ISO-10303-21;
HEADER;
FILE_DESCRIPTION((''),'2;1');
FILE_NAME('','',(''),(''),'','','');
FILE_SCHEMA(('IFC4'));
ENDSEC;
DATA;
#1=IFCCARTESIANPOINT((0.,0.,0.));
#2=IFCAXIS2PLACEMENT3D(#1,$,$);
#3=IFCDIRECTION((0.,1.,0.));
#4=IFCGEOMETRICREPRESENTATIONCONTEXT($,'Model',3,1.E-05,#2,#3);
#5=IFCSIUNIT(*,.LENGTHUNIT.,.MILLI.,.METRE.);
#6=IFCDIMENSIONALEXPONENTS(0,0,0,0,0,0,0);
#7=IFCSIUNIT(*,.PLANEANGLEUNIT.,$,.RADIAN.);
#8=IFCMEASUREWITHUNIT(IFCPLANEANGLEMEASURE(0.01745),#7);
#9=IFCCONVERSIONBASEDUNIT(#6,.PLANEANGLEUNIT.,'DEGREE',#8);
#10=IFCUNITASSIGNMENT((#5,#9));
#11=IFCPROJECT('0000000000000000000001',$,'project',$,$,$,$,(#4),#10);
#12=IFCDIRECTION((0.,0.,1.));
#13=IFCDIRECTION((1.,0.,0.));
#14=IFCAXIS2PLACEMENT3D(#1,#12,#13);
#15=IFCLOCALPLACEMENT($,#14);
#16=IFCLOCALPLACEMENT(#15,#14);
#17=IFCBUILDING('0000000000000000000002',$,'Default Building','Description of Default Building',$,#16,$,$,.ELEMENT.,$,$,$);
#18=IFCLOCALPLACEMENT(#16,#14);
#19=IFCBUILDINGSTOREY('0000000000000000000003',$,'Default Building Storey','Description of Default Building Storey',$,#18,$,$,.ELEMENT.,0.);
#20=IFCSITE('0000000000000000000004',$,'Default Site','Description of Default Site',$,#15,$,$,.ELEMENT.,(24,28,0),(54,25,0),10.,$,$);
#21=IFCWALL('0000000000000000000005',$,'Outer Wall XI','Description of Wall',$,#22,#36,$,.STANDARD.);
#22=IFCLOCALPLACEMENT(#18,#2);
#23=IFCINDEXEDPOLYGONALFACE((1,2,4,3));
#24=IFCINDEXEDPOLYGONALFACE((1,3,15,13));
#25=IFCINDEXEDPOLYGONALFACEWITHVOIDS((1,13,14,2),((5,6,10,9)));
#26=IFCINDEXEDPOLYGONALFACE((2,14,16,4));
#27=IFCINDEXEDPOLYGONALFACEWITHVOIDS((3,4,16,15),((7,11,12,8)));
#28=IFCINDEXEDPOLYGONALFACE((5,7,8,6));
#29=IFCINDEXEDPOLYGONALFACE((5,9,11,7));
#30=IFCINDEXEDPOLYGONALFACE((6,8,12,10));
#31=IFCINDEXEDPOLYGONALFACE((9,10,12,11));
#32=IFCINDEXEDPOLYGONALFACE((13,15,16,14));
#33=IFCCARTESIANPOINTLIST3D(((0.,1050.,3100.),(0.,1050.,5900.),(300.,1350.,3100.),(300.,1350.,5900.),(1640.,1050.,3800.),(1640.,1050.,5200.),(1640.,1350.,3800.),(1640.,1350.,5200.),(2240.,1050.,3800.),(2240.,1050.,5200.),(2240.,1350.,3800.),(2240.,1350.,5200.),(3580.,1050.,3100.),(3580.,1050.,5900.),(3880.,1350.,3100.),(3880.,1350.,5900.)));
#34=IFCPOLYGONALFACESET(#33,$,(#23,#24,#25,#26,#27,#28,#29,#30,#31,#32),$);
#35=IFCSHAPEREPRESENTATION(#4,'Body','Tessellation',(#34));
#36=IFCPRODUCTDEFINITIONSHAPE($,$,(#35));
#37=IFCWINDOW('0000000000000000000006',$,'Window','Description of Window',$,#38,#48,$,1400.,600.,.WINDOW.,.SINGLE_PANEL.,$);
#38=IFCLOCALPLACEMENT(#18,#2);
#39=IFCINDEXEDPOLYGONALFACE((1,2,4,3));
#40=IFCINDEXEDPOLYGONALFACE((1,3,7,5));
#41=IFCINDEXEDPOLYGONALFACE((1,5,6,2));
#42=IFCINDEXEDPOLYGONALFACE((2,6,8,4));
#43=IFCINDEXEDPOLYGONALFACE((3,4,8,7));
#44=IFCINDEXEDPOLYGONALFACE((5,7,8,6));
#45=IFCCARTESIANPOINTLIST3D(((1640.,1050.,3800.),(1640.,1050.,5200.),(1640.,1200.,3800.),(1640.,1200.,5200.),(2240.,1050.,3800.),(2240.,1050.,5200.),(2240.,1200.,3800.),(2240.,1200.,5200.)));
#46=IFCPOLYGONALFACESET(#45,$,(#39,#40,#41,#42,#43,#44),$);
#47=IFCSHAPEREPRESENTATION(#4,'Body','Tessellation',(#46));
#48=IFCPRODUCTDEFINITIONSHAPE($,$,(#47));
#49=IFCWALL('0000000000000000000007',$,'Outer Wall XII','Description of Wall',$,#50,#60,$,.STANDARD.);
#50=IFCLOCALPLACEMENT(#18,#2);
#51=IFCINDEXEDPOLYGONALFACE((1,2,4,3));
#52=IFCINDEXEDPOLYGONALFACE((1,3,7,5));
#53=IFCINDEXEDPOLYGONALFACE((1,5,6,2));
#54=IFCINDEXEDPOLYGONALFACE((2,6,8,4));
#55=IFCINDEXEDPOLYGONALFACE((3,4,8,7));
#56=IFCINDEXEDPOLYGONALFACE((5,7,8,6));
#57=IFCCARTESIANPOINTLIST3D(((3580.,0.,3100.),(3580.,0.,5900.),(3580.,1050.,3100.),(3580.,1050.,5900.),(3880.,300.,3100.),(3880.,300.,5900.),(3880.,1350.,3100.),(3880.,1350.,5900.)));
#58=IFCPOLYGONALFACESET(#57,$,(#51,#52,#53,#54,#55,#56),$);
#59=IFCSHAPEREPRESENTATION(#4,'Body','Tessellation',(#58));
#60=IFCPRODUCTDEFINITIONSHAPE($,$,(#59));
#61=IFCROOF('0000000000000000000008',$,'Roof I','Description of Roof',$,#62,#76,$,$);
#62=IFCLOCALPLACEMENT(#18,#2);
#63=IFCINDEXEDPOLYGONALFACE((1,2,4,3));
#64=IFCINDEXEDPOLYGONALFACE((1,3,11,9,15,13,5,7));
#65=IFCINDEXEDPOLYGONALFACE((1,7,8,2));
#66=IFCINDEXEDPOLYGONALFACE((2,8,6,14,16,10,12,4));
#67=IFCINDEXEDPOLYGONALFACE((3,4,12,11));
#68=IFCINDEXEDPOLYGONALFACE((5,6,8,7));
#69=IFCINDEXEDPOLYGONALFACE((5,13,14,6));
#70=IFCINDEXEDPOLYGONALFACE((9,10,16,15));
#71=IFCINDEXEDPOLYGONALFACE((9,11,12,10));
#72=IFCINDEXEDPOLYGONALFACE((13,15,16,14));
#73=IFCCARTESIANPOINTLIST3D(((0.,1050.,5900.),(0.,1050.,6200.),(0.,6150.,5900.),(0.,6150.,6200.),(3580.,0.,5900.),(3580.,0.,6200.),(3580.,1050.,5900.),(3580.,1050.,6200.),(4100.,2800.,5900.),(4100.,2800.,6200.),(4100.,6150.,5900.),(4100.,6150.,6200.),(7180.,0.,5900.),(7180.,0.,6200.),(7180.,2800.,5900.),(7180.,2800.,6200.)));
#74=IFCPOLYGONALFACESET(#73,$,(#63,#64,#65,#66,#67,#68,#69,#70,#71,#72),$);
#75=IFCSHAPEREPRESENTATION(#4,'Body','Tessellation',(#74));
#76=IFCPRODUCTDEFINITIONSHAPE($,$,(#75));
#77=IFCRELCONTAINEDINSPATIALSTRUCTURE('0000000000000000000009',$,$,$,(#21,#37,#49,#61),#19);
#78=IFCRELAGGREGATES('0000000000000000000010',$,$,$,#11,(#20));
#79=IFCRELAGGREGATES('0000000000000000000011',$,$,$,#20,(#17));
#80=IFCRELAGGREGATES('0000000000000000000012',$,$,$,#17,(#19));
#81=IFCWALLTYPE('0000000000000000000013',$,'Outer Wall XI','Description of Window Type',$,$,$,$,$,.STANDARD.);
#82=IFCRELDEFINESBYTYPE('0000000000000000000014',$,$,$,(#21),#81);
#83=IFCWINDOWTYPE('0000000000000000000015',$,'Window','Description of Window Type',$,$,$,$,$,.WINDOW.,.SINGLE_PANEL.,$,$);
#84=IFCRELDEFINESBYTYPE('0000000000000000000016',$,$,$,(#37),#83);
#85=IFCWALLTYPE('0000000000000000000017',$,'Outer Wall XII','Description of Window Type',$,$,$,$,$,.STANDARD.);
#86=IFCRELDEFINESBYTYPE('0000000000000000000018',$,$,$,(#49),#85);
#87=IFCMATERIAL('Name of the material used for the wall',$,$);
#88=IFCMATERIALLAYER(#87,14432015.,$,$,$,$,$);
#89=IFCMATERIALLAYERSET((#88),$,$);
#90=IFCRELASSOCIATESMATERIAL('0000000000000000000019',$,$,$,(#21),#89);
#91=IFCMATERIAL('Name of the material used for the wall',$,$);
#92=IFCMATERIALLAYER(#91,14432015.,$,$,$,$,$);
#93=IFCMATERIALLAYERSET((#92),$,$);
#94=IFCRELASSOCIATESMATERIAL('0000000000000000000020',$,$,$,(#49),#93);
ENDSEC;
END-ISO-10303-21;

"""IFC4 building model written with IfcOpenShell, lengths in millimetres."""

from ifc_helpers import new_model, entity, si_unit, converted_unit, direction, frame, origin, origin_with_axes, place, context, project, spatial, polyline, outline, extrude, material, layer, layer_set, layer_usage, type_object, element, fill, save


model = new_model("IFC4")

# Units and contexts
model_context = context("Model", 3, precision=1e-05, world=origin(), true_north=direction((0.0, 1.0, 0.0)))
ifc_project = project(units=[si_unit("LENGTHUNIT", "METRE", prefix="MILLI"), converted_unit("PLANEANGLEUNIT", "DEGREE", entity("IfcPlaneAngleMeasure", 0.01745), si_unit("PLANEANGLEUNIT", "RADIAN"), dimensions=[0, 0, 0, 0, 0, 0, 0])], contexts=[model_context])

# Site, building, storey
site_placement = place(None, origin_with_axes())
site = spatial("IfcSite", under=ifc_project, at=site_placement, Name="Default Site", Description="Description of Default Site", CompositionType="ELEMENT", RefLatitude=(24, 28, 0), RefLongitude=(54, 25, 0), RefElevation=10.0)
building_placement = place(site_placement, origin_with_axes())
building = spatial("IfcBuilding", under=site, at=building_placement, Name="Default Building", Description="Description of Default Building", CompositionType="ELEMENT")
storey_placement = place(building_placement, origin_with_axes())
storey = spatial("IfcBuildingStorey", under=building, at=storey_placement, Name="Default Building Storey", Description="Description of Default Building Storey", CompositionType="ELEMENT", Elevation=0.0)

# Wall, opening, window
ifc_material_1 = material(Name="Name of the material used for the wall")
ifc_layer_1 = layer(ifc_material_1, 14432015.0)
ifc_layer_set_1 = layer_set([ifc_layer_1])
ifc_layer_usage_1 = layer_usage(ifc_layer_set_1, "AXIS2", "POSITIVE", -7216007.5)
wall_type_1 = type_object("IfcWallType", Name="Outer Wall XI", Description="Description of Window Type", PredefinedType="STANDARD")
wall_1_placement = place(storey_placement, frame((150.0, 1200.0, 3100.0), z_axis=(0.0, 0.0, 1.0), x_axis=(1.0, 0.0, 0.0)))
wall_1 = element("IfcWall", 1, at=wall_1_placement, inside=storey, type_object=wall_type_1, material=ifc_layer_usage_1, Name="Outer Wall XI", Description="Description of Wall", PredefinedType="STANDARD", context=model_context, shape_type="SweptSolid", body=[
    extrude(outline(polyline([(-150.0, -150.0), (150.0, 150.0), (3730.0, 150.0), (3430.0, -150.0), (-150.0, -150.0)])), origin_with_axes(), (0.0, 0.0, 1.0), 2800.0),
])
opening_1_placement = place(wall_1_placement, frame((1490.0, -150.0, 700.0), z_axis=(0.0, 0.0, 1.0), x_axis=(1.0, 0.0, 0.0)))
opening_1 = element("IfcOpeningElement", 2, at=opening_1_placement, cuts=wall_1, context=model_context, shape_type="SweptSolid", body=[
    extrude(outline(polyline([(0.0, 0.0), (0.0, 300.0), (600.0, 300.0), (600.0, 0.0), (0.0, 0.0)])), origin_with_axes(), (0.0, 0.0, 1.0), 1400.0),
])
window_type_1 = type_object("IfcWindowType", Name="Window", Description="Description of Window Type", PartitioningType="SINGLE_PANEL", PredefinedType="WINDOW")
window_1_placement = place(opening_1_placement, origin_with_axes())
window_1 = element("IfcWindow", 3, at=window_1_placement, inside=storey, type_object=window_type_1, Name="Window", Description="Description of Window", OverallHeight=1400.0, OverallWidth=600.0, PartitioningType="SINGLE_PANEL", PredefinedType="WINDOW", context=model_context, shape_type="SweptSolid", body=[
    extrude(outline(polyline([(0.0, 0.0), (0.0, 150.0), (600.0, 150.0), (600.0, 0.0), (0.0, 0.0)])), origin_with_axes(), (0.0, 0.0, 1.0), 1400.0),
])
fill(opening_1, window_1)

# Wall
ifc_material_2 = material(Name="Name of the material used for the wall")
ifc_layer_2 = layer(ifc_material_2, 14432015.0)
ifc_layer_set_2 = layer_set([ifc_layer_2])
ifc_layer_usage_2 = layer_usage(ifc_layer_set_2, "AXIS2", "POSITIVE", -7216007.5)
wall_type_2 = type_object("IfcWallType", Name="Outer Wall XII", Description="Description of Window Type", PredefinedType="STANDARD")
wall_2_placement = place(storey_placement, frame((3730.0, 1200.0, 3100.0), z_axis=(0.0, 0.0, 1.0), x_axis=(0.0, -1.0, 0.0)))
element("IfcWall", 4, at=wall_2_placement, inside=storey, type_object=wall_type_2, material=ifc_layer_usage_2, Name="Outer Wall XII", Description="Description of Wall", PredefinedType="STANDARD", context=model_context, shape_type="SweptSolid", body=[
    extrude(outline(polyline([(150.0, -150.0), (-150.0, 150.0), (900.0, 150.0), (1200.0, -150.0), (150.0, -150.0)])), origin_with_axes(), (0.0, 0.0, 1.0), 2800.0),
])

# Roof
roof_placement = place(storey_placement, frame((0.0, 0.0, 5900.0), z_axis=(0.0, 0.0, 1.0), x_axis=(1.0, 0.0, 0.0)))
element("IfcRoof", 5, at=roof_placement, inside=storey, Name="Roof I", Description="Description of Roof", context=model_context, shape_type="SweptSolid", body=[
    extrude(outline(polyline([(0.0, 1050.0), (0.0, 6150.0), (4100.0, 6150.0), (4100.0, 2800.0), (7180.0, 2800.0), (7180.0, 0.0), (3580.0, 0.0), (3580.0, 1050.0), (0.0, 1050.0)])), origin_with_axes(), (0.0, 0.0, 1.0), 300.0),
])

save(model, "model.ifc")
